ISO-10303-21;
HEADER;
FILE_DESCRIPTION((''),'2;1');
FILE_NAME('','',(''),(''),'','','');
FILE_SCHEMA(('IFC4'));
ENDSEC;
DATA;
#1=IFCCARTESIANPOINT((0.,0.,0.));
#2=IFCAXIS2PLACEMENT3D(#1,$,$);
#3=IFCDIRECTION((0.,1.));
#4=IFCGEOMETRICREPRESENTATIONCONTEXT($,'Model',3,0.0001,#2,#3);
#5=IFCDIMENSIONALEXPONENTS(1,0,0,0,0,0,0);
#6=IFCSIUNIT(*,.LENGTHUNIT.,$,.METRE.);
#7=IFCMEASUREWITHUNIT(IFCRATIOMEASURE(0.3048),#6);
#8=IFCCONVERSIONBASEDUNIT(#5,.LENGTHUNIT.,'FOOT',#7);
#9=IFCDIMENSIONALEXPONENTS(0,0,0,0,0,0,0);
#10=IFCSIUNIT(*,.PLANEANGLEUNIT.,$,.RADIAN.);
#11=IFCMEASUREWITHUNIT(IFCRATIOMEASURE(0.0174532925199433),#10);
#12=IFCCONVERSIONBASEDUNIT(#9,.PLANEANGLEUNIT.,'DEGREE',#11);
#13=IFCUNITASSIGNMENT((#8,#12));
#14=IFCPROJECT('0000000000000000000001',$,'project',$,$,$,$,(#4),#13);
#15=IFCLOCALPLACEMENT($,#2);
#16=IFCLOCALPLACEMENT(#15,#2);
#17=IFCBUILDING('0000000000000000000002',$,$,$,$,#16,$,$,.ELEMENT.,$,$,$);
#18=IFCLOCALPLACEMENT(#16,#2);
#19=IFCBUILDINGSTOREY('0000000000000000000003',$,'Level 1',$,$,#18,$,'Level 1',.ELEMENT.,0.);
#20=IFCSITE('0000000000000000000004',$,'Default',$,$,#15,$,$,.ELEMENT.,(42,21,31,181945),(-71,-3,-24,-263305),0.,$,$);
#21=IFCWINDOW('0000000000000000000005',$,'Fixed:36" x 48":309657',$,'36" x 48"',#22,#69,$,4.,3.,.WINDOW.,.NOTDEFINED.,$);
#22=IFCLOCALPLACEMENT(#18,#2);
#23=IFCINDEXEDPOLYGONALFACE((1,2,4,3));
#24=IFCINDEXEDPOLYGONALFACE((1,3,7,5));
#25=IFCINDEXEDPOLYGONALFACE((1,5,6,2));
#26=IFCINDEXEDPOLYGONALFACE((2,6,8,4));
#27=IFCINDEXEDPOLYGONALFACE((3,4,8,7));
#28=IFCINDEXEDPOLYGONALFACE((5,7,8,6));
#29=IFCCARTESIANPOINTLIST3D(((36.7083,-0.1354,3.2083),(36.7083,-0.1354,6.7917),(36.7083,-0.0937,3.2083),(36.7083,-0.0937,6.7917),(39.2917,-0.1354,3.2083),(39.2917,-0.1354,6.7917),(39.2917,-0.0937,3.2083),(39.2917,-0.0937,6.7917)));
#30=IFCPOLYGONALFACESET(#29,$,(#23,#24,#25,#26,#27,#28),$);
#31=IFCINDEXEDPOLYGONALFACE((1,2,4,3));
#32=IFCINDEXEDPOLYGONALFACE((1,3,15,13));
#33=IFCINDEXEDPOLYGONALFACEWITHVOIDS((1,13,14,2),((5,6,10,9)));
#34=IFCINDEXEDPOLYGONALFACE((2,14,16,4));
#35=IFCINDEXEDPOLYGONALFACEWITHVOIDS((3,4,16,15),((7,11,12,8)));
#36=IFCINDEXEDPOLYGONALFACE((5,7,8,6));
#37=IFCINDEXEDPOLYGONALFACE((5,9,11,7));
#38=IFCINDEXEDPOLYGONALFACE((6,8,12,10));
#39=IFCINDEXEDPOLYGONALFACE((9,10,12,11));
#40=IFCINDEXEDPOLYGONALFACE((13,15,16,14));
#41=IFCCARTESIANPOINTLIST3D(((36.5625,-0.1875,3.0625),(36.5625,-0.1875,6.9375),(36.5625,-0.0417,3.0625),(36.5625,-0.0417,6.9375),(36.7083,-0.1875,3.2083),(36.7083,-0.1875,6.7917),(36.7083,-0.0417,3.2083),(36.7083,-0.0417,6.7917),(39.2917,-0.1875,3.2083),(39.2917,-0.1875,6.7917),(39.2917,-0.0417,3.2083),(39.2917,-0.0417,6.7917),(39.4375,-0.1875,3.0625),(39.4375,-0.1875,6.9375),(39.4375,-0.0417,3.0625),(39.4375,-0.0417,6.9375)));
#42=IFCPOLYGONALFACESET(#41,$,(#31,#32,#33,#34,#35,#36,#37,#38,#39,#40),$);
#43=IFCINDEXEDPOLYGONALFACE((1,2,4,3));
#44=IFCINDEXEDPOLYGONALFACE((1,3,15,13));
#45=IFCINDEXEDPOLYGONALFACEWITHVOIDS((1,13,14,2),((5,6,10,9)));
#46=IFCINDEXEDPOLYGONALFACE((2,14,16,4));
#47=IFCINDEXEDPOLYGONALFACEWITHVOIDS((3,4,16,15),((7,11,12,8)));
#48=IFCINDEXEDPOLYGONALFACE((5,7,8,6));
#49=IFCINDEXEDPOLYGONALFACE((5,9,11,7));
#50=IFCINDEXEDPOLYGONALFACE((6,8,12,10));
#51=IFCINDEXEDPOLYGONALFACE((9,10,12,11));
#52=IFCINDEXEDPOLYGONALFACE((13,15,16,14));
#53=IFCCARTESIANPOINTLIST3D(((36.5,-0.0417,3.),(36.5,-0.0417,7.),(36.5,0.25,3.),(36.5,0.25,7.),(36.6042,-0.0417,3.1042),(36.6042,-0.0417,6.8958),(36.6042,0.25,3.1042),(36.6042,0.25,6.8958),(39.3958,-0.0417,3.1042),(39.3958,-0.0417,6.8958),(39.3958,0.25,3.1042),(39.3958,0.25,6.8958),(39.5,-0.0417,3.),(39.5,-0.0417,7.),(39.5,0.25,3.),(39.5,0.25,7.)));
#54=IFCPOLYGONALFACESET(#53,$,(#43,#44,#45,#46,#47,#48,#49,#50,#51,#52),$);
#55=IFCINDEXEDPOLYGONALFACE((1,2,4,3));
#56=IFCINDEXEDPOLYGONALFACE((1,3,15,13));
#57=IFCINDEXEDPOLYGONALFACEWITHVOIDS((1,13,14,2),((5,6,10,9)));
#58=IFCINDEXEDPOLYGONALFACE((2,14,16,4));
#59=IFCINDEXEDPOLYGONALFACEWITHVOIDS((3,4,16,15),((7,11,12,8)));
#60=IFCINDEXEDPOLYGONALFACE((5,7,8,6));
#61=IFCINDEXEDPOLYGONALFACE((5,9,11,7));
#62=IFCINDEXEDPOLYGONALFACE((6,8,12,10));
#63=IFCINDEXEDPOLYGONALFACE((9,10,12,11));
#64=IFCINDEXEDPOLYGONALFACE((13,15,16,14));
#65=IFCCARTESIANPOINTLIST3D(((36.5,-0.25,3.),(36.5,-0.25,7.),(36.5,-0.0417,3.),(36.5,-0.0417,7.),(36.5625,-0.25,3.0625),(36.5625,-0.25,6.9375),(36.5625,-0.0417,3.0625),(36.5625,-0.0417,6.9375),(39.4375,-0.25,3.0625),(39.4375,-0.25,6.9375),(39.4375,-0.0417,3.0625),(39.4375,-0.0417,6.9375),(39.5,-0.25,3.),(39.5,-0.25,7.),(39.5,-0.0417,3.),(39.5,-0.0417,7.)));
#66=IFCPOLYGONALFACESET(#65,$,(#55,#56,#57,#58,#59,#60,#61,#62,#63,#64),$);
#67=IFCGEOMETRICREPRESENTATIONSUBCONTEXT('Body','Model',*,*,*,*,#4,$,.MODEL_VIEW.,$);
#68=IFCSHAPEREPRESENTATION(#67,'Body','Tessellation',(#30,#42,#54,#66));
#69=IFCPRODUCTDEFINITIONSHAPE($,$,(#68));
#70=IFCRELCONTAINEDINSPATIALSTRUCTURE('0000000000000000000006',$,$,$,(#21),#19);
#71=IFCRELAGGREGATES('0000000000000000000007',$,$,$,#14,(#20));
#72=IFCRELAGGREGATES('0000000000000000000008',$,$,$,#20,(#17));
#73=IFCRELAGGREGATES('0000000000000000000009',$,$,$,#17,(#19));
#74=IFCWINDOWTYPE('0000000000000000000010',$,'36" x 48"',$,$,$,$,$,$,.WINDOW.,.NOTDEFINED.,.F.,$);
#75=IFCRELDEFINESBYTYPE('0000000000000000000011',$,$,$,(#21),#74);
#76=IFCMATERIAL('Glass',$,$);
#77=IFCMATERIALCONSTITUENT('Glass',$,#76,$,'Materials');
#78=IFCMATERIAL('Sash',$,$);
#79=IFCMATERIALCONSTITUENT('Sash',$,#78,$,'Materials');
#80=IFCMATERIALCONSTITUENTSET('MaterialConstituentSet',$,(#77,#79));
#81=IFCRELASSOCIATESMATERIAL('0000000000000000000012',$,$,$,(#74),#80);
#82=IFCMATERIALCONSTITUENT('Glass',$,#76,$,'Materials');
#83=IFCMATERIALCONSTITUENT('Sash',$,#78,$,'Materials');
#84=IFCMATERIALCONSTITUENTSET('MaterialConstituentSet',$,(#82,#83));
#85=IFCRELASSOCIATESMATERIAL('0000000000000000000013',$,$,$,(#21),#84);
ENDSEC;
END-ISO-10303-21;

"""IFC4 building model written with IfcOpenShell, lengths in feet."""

from ifc_helpers import new_model, entity, si_unit, converted_unit, direction, frame, frame_2d, origin, place, context, subcontext, project, spatial, polyline, rectangle, outline, extrude, source, transform, mapped, material, constituent, constituent_set, type_object, type_shapes, element, save


model = new_model("IFC4")

# Units and contexts
model_context = context("Model", 3, precision=0.0001, world=origin(), true_north=direction((0.0, 1.0)))
body_context = subcontext(model_context, "Body", "Model", "MODEL_VIEW")
ifc_project = project(units=[converted_unit("LENGTHUNIT", "FOOT", entity("IfcRatioMeasure", 0.3048), si_unit("LENGTHUNIT", "METRE"), dimensions=[1, 0, 0, 0, 0, 0, 0]), converted_unit("PLANEANGLEUNIT", "DEGREE", entity("IfcRatioMeasure", 0.0174532925199433), si_unit("PLANEANGLEUNIT", "RADIAN"), dimensions=[0, 0, 0, 0, 0, 0, 0])], contexts=[model_context])

# Site, building, storey
site_placement = place(None, origin())
site = spatial("IfcSite", under=ifc_project, at=site_placement, Name="Default", CompositionType="ELEMENT", RefLatitude=(42, 21, 31, 181945), RefLongitude=(-71, -3, -24, -263305), RefElevation=0.0)
building_placement = place(site_placement, origin())
building = spatial("IfcBuilding", under=site, at=building_placement, CompositionType="ELEMENT")
storey_placement = place(building_placement, origin())
storey = spatial("IfcBuildingStorey", under=building, at=storey_placement, Name="Level 1", LongName="Level 1", CompositionType="ELEMENT", Elevation=0.0)

# Shared definitions
placement_1 = place(storey_placement, frame((46.25, 0.0, 0.0), z_axis=(0.0, 0.0, 1.0), x_axis=(-1.0, 0.0, 0.0)))

# Window
ifc_material_1 = material(Name="Glass")
ifc_constituent_1 = constituent(ifc_material_1, Name="Glass", Category="Materials")
ifc_material_2 = material(Name="Sash")
ifc_constituent_2 = constituent(ifc_material_2, Name="Sash", Category="Materials")
ifc_constituent_set_1 = constituent_set(constituents=[ifc_constituent_1, ifc_constituent_2], Name="MaterialConstituentSet")
ifc_constituent_3 = constituent(ifc_material_1, Name="Glass", Category="Materials")
ifc_constituent_4 = constituent(ifc_material_2, Name="Sash", Category="Materials")
ifc_constituent_set_2 = constituent_set(constituents=[ifc_constituent_3, ifc_constituent_4], Name="MaterialConstituentSet")
window_type = type_object("IfcWindowType", Name="36\" x 48\"", ParameterTakesPrecedence=False, PartitioningType="NOTDEFINED", PredefinedType="WINDOW", material=ifc_constituent_set_2)
shared_shape = source(origin(), body_context, "Body", "SweptSolid", [
    extrude(rectangle(XDim=0.0417, YDim=2.5833, at=frame_2d((0.0, 0.0), x_axis=(1.0, 0.0))), frame((1.5, 0.3646, 0.2083), z_axis=(0.0, 0.0, 1.0), x_axis=(0.0, 1.0, 0.0)), (0.0, 0.0, 1.0), 3.5833),
    extrude(outline(polyline([(-1.4375, -1.9375), (1.4375, -1.9375), (1.4375, 1.9375), (-1.4375, 1.9375), (-1.4375, -1.9375)]), holes=[polyline([(-1.2917, -1.7917), (-1.2917, 1.7917), (1.2917, 1.7917), (1.2917, -1.7917), (-1.2917, -1.7917)])]), frame((1.5, 0.2917, 2.0), z_axis=(0.0, 1.0, 0.0), x_axis=(1.0, 0.0, 0.0)), (0.0, 0.0, 1.0), 0.1458),
    extrude(outline(polyline([(-1.5, -2.0), (1.5, -2.0), (1.5, 2.0), (-1.5, 2.0), (-1.5, -2.0)]), holes=[polyline([(-1.3958, -1.8958), (-1.3958, 1.8958), (1.3958, 1.8958), (1.3958, -1.8958), (-1.3958, -1.8958)])]), frame((1.5, 0.0, 2.0), z_axis=(0.0, 1.0, 0.0), x_axis=(1.0, 0.0, 0.0)), (0.0, 0.0, 1.0), 0.2917),
    extrude(outline(polyline([(-2.0, -1.5), (2.0, -1.5), (2.0, 1.5), (-2.0, 1.5), (-2.0, -1.5)]), holes=[polyline([(-1.9375, -1.4375), (-1.9375, 1.4375), (1.9375, 1.4375), (1.9375, -1.4375), (-1.9375, -1.4375)])]), frame((1.5, 0.2917, 2.0), z_axis=(0.0, 1.0, 0.0), x_axis=(0.0, 0.0, -1.0)), (0.0, 0.0, 1.0), 0.2083),
])
type_shapes(window_type, [shared_shape])
placement_2 = place(placement_1, frame((6.75, -0.25, 3.0)))
window_placement = place(placement_2, origin())
element("IfcWindow", 1, at=window_placement, inside=storey, type_object=window_type, material=ifc_constituent_set_1, Name="Fixed:36\" x 48\":309657", ObjectType="36\" x 48\"", OverallHeight=4.0, OverallWidth=3.0, PartitioningType="NOTDEFINED", PredefinedType="WINDOW", context=body_context, shape_type="MappedRepresentation", body=[
    mapped(shared_shape, transform((0.0, 0.0, 0.0), scale=1.0)),
])

save(model, "model.ifc")
